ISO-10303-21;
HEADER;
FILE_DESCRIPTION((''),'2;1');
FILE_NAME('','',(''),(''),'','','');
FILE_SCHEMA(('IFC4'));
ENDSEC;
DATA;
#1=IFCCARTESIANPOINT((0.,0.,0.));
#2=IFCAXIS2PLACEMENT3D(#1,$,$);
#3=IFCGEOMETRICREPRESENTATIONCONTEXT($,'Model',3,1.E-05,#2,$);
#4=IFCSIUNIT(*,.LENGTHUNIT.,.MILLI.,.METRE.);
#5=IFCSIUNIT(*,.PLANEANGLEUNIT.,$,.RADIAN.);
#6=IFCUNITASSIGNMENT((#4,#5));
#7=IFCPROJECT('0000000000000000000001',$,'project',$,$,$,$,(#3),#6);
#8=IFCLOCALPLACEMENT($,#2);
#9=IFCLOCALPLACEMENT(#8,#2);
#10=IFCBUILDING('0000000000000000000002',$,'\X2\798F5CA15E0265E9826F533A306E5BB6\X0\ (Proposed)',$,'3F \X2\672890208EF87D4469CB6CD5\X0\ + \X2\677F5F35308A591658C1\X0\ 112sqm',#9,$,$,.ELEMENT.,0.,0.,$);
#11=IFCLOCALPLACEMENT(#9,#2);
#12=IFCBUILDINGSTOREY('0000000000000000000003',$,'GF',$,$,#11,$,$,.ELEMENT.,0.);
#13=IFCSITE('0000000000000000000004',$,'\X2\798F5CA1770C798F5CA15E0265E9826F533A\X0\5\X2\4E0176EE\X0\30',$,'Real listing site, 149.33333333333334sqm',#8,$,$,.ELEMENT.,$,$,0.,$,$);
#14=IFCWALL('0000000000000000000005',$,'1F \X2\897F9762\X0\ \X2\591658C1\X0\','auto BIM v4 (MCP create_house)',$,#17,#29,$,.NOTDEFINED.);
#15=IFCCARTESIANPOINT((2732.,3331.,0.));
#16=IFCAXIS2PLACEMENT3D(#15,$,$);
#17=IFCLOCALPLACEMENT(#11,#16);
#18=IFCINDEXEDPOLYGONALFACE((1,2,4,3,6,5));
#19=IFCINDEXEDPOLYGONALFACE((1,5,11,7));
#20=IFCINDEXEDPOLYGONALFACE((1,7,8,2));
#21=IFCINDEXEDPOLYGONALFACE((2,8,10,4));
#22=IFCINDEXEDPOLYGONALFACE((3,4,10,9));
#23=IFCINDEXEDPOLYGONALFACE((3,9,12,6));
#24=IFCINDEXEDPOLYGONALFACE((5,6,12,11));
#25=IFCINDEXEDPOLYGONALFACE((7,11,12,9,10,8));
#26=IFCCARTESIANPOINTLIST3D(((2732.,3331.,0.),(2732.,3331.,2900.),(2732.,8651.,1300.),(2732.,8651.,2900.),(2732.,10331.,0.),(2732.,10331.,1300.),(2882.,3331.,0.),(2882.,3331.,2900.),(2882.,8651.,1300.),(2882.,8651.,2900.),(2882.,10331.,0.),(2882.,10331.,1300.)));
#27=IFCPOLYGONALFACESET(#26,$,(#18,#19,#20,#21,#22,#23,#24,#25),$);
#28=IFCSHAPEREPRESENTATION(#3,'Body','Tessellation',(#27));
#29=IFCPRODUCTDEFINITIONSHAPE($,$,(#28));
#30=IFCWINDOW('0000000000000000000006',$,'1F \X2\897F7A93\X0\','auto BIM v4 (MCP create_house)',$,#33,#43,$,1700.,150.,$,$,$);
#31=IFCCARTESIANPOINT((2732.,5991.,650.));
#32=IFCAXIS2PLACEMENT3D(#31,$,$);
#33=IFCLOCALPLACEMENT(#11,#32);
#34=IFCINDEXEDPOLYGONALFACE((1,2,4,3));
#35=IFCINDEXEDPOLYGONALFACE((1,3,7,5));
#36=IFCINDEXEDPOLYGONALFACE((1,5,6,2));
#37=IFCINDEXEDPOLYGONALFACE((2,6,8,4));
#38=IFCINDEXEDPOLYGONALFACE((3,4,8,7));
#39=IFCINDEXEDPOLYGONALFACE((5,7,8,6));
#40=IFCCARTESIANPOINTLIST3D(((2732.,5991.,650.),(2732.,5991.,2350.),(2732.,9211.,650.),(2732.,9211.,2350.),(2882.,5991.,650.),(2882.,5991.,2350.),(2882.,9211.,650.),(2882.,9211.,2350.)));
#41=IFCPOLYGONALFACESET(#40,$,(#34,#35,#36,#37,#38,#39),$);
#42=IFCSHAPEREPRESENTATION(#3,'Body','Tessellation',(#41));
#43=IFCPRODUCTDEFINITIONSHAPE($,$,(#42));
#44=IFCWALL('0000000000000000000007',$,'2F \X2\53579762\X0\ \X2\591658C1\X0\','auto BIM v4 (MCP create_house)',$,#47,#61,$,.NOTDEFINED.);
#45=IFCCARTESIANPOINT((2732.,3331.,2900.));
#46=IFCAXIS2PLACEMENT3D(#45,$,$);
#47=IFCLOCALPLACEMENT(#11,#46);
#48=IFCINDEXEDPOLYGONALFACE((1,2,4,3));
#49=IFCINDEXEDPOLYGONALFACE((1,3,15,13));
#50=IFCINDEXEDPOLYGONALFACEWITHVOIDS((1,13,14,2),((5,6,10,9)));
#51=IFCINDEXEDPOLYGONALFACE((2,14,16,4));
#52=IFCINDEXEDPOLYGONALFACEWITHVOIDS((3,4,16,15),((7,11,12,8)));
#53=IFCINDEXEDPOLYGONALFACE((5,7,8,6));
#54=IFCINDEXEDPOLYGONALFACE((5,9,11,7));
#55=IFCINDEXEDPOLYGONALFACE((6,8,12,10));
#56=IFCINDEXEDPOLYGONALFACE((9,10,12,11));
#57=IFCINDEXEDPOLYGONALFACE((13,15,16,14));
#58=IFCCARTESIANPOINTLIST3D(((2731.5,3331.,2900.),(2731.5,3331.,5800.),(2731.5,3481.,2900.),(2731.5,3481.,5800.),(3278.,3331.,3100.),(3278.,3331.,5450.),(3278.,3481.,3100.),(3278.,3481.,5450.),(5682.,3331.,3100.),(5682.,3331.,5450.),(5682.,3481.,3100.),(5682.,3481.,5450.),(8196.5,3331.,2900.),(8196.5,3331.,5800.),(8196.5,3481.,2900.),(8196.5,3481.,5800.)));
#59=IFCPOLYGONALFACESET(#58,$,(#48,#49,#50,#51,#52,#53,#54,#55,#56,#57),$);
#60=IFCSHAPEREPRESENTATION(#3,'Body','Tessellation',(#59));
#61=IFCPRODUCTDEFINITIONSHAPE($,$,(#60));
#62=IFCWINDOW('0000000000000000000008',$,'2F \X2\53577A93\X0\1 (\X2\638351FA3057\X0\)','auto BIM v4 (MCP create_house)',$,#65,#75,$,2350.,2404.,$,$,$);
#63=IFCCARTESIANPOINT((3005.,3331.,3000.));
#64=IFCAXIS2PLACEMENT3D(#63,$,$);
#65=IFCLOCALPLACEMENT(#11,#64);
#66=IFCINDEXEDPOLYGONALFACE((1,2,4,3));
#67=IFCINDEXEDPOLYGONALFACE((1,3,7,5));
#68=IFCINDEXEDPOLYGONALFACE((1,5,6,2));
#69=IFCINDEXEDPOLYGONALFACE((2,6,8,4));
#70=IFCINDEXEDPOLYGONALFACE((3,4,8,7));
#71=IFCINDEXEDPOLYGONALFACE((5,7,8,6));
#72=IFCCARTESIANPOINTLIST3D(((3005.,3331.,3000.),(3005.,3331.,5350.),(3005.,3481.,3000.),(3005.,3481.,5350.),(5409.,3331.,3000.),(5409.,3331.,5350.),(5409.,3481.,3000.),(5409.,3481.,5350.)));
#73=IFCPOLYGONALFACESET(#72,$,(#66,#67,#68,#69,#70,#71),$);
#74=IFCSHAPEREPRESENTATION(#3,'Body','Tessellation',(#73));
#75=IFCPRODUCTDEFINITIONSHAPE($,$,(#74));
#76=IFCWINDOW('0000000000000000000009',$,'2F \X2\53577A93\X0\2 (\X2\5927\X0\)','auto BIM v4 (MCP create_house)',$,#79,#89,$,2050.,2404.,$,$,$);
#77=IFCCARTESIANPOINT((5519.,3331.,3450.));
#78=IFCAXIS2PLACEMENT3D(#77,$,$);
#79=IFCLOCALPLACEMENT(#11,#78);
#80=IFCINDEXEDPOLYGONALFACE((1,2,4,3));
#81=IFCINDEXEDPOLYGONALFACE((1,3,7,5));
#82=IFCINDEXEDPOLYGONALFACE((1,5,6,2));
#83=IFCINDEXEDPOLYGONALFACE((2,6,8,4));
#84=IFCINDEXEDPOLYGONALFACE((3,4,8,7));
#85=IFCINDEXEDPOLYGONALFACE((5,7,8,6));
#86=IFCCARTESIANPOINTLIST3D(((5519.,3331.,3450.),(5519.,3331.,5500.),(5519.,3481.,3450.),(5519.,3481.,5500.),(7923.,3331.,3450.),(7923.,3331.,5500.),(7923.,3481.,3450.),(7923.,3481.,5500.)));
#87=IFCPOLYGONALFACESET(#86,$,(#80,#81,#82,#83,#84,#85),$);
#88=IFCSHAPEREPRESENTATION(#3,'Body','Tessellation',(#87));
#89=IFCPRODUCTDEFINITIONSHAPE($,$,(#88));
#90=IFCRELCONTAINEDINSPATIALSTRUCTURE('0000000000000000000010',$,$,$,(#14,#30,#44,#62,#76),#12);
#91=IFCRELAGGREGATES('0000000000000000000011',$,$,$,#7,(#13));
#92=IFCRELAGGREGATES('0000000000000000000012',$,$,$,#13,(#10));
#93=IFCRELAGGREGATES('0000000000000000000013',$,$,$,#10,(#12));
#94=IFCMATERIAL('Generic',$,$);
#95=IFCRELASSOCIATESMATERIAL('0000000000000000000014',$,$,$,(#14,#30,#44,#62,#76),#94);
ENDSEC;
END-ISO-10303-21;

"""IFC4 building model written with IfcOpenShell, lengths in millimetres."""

from ifc_helpers import new_model, si_unit, frame, frame_2d, origin, place, context, project, spatial, rectangle, extrude, material, element, fill, save


model = new_model("IFC4")

# Units and contexts
model_context = context("Model", 3, precision=1e-05, world=origin())
ifc_project = project(units=[si_unit("LENGTHUNIT", "METRE", prefix="MILLI"), si_unit("PLANEANGLEUNIT", "RADIAN")], contexts=[model_context])

# Site, building, storey
site_placement = place(None, origin())
site = spatial("IfcSite", under=ifc_project, at=site_placement, Name="福岡県福岡市早良区5丁目30", ObjectType="Real listing site, 149.33333333333334sqm", CompositionType="ELEMENT", RefElevation=0.0)
building_placement = place(site_placement, origin())
building = spatial("IfcBuilding", under=site, at=building_placement, Name="福岡市早良区の家 (Proposed)", ObjectType="3F 木造軸組構法 + 板張り外壁 112sqm", CompositionType="ELEMENT", ElevationOfRefHeight=0.0, ElevationOfTerrain=0.0)
storey_placement = place(building_placement, origin())
storey = spatial("IfcBuildingStorey", under=building, at=storey_placement, Name="GF", CompositionType="ELEMENT", Elevation=0.0)

# Shared definitions
ifc_material = material(Name="Generic")

# Wall, opening, window
wall_1_placement = place(storey_placement, frame((2732.0, 3331.0, 0.0)))
wall_1 = element("IfcWall", 1, at=wall_1_placement, inside=storey, material=ifc_material, Name="1F 西面 外壁", Description="auto BIM v4 (MCP create_house)", PredefinedType="NOTDEFINED", context=model_context, shape_type="SweptSolid", body=[
    extrude(rectangle(XDim=150.0, YDim=7000.0, at=frame_2d((75.0, 3500.0))), frame((2732.0, 3331.0, 0.0)), (0.0, 0.0, 1.0), 2900.0),
])
opening_1_placement = place(storey_placement, frame((2732.0, 5991.0, 650.0)))
opening_1 = element("IfcOpeningElement", 2, at=opening_1_placement, cuts=wall_1, PredefinedType="NOTDEFINED", context=model_context, shape_type="SweptSolid", body=[
    extrude(rectangle(XDim=150.0, YDim=3220.0, at=frame_2d((75.0, 1610.0))), frame((2732.0, 5991.0, 650.0)), (0.0, 0.0, 1.0), 1700.0),
])
window_1_placement = place(storey_placement, frame((2732.0, 5991.0, 650.0)))
window_1 = element("IfcWindow", 3, at=window_1_placement, inside=storey, material=ifc_material, Name="1F 西窓", Description="auto BIM v4 (MCP create_house)", OverallHeight=1700.0, OverallWidth=150.0, context=model_context, shape_type="SweptSolid", body=[
    extrude(rectangle(XDim=150.0, YDim=3220.0, at=frame_2d((75.0, 1610.0))), frame((2732.0, 5991.0, 650.0)), (0.0, 0.0, 1.0), 1700.0),
])
fill(opening_1, window_1)

# Wall, openings, windows
wall_2_placement = place(storey_placement, frame((2732.0, 3331.0, 2900.0)))
wall_2 = element("IfcWall", 4, at=wall_2_placement, inside=storey, material=ifc_material, Name="2F 南面 外壁", Description="auto BIM v4 (MCP create_house)", PredefinedType="NOTDEFINED", context=model_context, shape_type="SweptSolid", body=[
    extrude(rectangle(XDim=5465.0, YDim=150.0, at=frame_2d((2732.0, 75.0))), frame((2732.0, 3331.0, 2900.0)), (0.0, 0.0, 1.0), 2900.0),
])
opening_2_placement = place(storey_placement, frame((3005.0, 3331.0, 3000.0)))
opening_2 = element("IfcOpeningElement", 5, at=opening_2_placement, cuts=wall_2, PredefinedType="NOTDEFINED", context=model_context, shape_type="SweptSolid", body=[
    extrude(rectangle(XDim=2404.0, YDim=150.0, at=frame_2d((1202.0, 75.0))), frame((3005.0, 3331.0, 3000.0)), (0.0, 0.0, 1.0), 2350.0),
])
opening_3_placement = place(storey_placement, frame((5519.0, 3331.0, 3450.0)))
opening_3 = element("IfcOpeningElement", 6, at=opening_3_placement, cuts=wall_2, PredefinedType="NOTDEFINED", context=model_context, shape_type="SweptSolid", body=[
    extrude(rectangle(XDim=2404.0, YDim=150.0, at=frame_2d((1202.0, 75.0))), frame((5519.0, 3331.0, 3450.0)), (0.0, 0.0, 1.0), 2050.0),
])
window_2_placement = place(storey_placement, frame((3005.0, 3331.0, 3000.0)))
window_2 = element("IfcWindow", 7, at=window_2_placement, inside=storey, material=ifc_material, Name="2F 南窓1 (掃出し)", Description="auto BIM v4 (MCP create_house)", OverallHeight=2350.0, OverallWidth=2404.0, context=model_context, shape_type="SweptSolid", body=[
    extrude(rectangle(XDim=2404.0, YDim=150.0, at=frame_2d((1202.0, 75.0))), frame((3005.0, 3331.0, 3000.0)), (0.0, 0.0, 1.0), 2350.0),
])
fill(opening_2, window_2)
window_3_placement = place(storey_placement, frame((5519.0, 3331.0, 3450.0)))
window_3 = element("IfcWindow", 8, at=window_3_placement, inside=storey, material=ifc_material, Name="2F 南窓2 (大)", Description="auto BIM v4 (MCP create_house)", OverallHeight=2050.0, OverallWidth=2404.0, context=model_context, shape_type="SweptSolid", body=[
    extrude(rectangle(XDim=2404.0, YDim=150.0, at=frame_2d((1202.0, 75.0))), frame((5519.0, 3331.0, 3450.0)), (0.0, 0.0, 1.0), 2050.0),
])
fill(opening_3, window_3)

save(model, "model.ifc")
